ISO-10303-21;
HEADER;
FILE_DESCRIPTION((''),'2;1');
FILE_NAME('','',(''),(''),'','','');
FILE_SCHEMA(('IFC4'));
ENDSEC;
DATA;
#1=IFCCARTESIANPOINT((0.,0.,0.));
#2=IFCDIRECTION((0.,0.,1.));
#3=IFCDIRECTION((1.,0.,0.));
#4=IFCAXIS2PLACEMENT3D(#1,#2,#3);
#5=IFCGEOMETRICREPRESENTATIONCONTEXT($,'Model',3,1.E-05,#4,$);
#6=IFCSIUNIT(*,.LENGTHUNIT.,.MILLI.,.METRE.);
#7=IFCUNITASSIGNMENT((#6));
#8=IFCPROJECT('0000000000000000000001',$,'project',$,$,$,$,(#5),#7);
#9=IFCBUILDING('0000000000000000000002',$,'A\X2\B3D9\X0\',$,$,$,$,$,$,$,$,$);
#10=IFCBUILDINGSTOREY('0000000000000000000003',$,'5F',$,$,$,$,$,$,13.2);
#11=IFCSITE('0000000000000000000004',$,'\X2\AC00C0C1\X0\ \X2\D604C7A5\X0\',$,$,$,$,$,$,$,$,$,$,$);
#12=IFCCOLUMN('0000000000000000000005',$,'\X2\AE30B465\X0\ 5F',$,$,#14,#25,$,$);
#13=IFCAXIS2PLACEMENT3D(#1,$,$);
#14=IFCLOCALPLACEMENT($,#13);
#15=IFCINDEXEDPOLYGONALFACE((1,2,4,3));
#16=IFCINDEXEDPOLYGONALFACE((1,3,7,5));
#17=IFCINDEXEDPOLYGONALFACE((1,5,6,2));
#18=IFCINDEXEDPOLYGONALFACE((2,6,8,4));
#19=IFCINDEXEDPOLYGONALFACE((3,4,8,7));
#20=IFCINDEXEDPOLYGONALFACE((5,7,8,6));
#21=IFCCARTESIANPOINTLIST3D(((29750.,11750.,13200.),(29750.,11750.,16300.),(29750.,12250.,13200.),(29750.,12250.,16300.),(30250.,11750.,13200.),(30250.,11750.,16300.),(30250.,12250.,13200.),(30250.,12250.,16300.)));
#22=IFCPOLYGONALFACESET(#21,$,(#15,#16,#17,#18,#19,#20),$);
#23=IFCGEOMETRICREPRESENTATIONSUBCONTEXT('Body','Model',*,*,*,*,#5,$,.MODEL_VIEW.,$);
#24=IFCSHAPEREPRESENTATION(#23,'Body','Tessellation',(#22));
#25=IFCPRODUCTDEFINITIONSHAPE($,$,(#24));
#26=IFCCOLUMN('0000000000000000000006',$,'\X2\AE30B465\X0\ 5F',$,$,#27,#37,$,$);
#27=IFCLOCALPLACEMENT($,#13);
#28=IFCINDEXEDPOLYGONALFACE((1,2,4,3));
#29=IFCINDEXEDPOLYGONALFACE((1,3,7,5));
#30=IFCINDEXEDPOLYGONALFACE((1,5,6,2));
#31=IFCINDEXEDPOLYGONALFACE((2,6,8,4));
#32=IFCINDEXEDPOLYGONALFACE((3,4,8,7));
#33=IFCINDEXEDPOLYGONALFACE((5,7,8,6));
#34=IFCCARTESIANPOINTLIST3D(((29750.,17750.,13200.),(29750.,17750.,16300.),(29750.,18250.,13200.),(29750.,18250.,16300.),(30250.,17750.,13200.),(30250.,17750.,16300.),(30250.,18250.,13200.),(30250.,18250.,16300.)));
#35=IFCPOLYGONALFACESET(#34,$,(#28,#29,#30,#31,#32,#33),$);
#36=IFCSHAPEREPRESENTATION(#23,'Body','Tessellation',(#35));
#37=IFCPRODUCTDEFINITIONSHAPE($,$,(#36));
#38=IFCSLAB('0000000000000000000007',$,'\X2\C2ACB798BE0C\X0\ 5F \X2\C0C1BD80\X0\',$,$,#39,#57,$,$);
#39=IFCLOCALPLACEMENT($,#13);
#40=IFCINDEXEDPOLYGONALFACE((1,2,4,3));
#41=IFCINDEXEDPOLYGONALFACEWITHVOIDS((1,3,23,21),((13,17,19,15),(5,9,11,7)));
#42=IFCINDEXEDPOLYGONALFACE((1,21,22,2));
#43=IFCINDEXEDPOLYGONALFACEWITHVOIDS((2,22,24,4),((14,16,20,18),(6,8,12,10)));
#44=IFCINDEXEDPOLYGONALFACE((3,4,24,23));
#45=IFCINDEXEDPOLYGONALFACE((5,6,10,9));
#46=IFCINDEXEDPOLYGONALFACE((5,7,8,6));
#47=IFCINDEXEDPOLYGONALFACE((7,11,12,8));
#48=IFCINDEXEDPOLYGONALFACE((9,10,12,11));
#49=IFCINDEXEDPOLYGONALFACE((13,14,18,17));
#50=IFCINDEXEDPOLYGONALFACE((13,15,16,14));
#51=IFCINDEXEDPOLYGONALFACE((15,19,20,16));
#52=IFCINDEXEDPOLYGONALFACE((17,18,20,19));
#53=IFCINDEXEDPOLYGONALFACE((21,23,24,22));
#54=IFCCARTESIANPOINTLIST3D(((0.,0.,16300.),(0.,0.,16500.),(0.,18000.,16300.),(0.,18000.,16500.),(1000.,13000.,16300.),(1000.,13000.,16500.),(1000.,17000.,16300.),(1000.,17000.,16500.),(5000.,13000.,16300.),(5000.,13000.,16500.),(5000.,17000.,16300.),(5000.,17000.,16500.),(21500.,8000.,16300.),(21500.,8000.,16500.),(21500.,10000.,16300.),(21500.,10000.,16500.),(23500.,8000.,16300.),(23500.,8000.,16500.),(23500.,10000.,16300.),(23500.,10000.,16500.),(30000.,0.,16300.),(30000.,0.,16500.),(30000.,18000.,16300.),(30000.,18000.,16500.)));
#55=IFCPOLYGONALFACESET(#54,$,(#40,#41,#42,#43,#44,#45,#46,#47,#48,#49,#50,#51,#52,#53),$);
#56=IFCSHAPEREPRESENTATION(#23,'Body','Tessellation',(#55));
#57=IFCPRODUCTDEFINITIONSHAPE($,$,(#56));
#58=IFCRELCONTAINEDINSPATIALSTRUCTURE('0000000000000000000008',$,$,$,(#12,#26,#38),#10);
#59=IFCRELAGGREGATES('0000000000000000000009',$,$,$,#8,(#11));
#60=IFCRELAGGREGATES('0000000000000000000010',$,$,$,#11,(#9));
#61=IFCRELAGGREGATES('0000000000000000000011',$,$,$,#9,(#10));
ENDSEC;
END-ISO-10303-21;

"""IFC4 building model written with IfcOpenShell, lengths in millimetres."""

from ifc_helpers import new_model, si_unit, frame, origin_with_axes, place, context, subcontext, project, spatial, indexed_curve, outline, extrude, element, save


model = new_model("IFC4")

# Units and contexts
model_context = context("Model", 3, precision=1e-05, world=origin_with_axes())
body_context = subcontext(model_context, "Body", "Model", "MODEL_VIEW")
ifc_project = project(units=[si_unit("LENGTHUNIT", "METRE", prefix="MILLI")], contexts=[model_context])

# Site, building, storey
site = spatial("IfcSite", under=ifc_project, Name="가상 현장")
building = spatial("IfcBuilding", under=site, Name="A동")
storey = spatial("IfcBuildingStorey", under=building, Name="5F", Elevation=13.2)

# Columns
for number, where, z_axis, x_axis, name in (
    (1, (29750.0, 11750.0, 13200.0), (0.0, 0.0, 1.0), (1.0, 0.0, 0.0), "기둥 5F"),
    (2, (29750.0, 17750.0, 13200.0), (0.0, 0.0, 1.0), (1.0, 0.0, 0.0), "기둥 5F"),
):
    element("IfcColumn", number, at=place(None, frame(where, z_axis=z_axis, x_axis=x_axis)), inside=storey, Name=name, context=body_context, shape_type="SweptSolid", body=[
        extrude(outline(indexed_curve([(0.0, 0.0), (0.0, 500.0), (500.0, 500.0), (500.0, 0.0), (0.0, 0.0)], self_intersect=False)), origin_with_axes(), (0.0, 0.0, 1.0), 3100.0),
    ])

# Slab, openings
slab_placement = place(None, frame((0.0, 0.0, 16300.0), z_axis=(0.0, 0.0, 1.0), x_axis=(1.0, 0.0, 0.0)))
slab = element("IfcSlab", 3, at=slab_placement, inside=storey, Name="슬래브 5F 상부", context=body_context, shape_type="SweptSolid", body=[
    extrude(outline(indexed_curve([(0.0, 0.0), (30000.0, 0.0), (30000.0, 18000.0), (0.0, 18000.0)])), None, (0.0, 0.0, 1.0), 200.0),
])
opening_1_placement = place(slab_placement, frame((1000.0, 13000.0, -10.0), z_axis=(0.0, 0.0, 1.0), x_axis=(1.0, 0.0, 0.0)))
element("IfcOpeningElement", 4, at=opening_1_placement, cuts=slab, context=body_context, shape_type="SweptSolid", body=[
    extrude(outline(indexed_curve([(0.0, 0.0), (4000.0, 0.0), (4000.0, 4000.0), (0.0, 4000.0)])), None, (0.0, 0.0, 1.0), 220.0),
])
opening_2_placement = place(slab_placement, frame((21500.0, 8000.0, -10.0), z_axis=(0.0, 0.0, 1.0), x_axis=(1.0, 0.0, 0.0)))
element("IfcOpeningElement", 5, at=opening_2_placement, cuts=slab, context=body_context, shape_type="SweptSolid", body=[
    extrude(outline(indexed_curve([(0.0, 0.0), (2000.0, 0.0), (2000.0, 2000.0), (0.0, 2000.0)])), None, (0.0, 0.0, 1.0), 220.0),
])

save(model, "model.ifc")
